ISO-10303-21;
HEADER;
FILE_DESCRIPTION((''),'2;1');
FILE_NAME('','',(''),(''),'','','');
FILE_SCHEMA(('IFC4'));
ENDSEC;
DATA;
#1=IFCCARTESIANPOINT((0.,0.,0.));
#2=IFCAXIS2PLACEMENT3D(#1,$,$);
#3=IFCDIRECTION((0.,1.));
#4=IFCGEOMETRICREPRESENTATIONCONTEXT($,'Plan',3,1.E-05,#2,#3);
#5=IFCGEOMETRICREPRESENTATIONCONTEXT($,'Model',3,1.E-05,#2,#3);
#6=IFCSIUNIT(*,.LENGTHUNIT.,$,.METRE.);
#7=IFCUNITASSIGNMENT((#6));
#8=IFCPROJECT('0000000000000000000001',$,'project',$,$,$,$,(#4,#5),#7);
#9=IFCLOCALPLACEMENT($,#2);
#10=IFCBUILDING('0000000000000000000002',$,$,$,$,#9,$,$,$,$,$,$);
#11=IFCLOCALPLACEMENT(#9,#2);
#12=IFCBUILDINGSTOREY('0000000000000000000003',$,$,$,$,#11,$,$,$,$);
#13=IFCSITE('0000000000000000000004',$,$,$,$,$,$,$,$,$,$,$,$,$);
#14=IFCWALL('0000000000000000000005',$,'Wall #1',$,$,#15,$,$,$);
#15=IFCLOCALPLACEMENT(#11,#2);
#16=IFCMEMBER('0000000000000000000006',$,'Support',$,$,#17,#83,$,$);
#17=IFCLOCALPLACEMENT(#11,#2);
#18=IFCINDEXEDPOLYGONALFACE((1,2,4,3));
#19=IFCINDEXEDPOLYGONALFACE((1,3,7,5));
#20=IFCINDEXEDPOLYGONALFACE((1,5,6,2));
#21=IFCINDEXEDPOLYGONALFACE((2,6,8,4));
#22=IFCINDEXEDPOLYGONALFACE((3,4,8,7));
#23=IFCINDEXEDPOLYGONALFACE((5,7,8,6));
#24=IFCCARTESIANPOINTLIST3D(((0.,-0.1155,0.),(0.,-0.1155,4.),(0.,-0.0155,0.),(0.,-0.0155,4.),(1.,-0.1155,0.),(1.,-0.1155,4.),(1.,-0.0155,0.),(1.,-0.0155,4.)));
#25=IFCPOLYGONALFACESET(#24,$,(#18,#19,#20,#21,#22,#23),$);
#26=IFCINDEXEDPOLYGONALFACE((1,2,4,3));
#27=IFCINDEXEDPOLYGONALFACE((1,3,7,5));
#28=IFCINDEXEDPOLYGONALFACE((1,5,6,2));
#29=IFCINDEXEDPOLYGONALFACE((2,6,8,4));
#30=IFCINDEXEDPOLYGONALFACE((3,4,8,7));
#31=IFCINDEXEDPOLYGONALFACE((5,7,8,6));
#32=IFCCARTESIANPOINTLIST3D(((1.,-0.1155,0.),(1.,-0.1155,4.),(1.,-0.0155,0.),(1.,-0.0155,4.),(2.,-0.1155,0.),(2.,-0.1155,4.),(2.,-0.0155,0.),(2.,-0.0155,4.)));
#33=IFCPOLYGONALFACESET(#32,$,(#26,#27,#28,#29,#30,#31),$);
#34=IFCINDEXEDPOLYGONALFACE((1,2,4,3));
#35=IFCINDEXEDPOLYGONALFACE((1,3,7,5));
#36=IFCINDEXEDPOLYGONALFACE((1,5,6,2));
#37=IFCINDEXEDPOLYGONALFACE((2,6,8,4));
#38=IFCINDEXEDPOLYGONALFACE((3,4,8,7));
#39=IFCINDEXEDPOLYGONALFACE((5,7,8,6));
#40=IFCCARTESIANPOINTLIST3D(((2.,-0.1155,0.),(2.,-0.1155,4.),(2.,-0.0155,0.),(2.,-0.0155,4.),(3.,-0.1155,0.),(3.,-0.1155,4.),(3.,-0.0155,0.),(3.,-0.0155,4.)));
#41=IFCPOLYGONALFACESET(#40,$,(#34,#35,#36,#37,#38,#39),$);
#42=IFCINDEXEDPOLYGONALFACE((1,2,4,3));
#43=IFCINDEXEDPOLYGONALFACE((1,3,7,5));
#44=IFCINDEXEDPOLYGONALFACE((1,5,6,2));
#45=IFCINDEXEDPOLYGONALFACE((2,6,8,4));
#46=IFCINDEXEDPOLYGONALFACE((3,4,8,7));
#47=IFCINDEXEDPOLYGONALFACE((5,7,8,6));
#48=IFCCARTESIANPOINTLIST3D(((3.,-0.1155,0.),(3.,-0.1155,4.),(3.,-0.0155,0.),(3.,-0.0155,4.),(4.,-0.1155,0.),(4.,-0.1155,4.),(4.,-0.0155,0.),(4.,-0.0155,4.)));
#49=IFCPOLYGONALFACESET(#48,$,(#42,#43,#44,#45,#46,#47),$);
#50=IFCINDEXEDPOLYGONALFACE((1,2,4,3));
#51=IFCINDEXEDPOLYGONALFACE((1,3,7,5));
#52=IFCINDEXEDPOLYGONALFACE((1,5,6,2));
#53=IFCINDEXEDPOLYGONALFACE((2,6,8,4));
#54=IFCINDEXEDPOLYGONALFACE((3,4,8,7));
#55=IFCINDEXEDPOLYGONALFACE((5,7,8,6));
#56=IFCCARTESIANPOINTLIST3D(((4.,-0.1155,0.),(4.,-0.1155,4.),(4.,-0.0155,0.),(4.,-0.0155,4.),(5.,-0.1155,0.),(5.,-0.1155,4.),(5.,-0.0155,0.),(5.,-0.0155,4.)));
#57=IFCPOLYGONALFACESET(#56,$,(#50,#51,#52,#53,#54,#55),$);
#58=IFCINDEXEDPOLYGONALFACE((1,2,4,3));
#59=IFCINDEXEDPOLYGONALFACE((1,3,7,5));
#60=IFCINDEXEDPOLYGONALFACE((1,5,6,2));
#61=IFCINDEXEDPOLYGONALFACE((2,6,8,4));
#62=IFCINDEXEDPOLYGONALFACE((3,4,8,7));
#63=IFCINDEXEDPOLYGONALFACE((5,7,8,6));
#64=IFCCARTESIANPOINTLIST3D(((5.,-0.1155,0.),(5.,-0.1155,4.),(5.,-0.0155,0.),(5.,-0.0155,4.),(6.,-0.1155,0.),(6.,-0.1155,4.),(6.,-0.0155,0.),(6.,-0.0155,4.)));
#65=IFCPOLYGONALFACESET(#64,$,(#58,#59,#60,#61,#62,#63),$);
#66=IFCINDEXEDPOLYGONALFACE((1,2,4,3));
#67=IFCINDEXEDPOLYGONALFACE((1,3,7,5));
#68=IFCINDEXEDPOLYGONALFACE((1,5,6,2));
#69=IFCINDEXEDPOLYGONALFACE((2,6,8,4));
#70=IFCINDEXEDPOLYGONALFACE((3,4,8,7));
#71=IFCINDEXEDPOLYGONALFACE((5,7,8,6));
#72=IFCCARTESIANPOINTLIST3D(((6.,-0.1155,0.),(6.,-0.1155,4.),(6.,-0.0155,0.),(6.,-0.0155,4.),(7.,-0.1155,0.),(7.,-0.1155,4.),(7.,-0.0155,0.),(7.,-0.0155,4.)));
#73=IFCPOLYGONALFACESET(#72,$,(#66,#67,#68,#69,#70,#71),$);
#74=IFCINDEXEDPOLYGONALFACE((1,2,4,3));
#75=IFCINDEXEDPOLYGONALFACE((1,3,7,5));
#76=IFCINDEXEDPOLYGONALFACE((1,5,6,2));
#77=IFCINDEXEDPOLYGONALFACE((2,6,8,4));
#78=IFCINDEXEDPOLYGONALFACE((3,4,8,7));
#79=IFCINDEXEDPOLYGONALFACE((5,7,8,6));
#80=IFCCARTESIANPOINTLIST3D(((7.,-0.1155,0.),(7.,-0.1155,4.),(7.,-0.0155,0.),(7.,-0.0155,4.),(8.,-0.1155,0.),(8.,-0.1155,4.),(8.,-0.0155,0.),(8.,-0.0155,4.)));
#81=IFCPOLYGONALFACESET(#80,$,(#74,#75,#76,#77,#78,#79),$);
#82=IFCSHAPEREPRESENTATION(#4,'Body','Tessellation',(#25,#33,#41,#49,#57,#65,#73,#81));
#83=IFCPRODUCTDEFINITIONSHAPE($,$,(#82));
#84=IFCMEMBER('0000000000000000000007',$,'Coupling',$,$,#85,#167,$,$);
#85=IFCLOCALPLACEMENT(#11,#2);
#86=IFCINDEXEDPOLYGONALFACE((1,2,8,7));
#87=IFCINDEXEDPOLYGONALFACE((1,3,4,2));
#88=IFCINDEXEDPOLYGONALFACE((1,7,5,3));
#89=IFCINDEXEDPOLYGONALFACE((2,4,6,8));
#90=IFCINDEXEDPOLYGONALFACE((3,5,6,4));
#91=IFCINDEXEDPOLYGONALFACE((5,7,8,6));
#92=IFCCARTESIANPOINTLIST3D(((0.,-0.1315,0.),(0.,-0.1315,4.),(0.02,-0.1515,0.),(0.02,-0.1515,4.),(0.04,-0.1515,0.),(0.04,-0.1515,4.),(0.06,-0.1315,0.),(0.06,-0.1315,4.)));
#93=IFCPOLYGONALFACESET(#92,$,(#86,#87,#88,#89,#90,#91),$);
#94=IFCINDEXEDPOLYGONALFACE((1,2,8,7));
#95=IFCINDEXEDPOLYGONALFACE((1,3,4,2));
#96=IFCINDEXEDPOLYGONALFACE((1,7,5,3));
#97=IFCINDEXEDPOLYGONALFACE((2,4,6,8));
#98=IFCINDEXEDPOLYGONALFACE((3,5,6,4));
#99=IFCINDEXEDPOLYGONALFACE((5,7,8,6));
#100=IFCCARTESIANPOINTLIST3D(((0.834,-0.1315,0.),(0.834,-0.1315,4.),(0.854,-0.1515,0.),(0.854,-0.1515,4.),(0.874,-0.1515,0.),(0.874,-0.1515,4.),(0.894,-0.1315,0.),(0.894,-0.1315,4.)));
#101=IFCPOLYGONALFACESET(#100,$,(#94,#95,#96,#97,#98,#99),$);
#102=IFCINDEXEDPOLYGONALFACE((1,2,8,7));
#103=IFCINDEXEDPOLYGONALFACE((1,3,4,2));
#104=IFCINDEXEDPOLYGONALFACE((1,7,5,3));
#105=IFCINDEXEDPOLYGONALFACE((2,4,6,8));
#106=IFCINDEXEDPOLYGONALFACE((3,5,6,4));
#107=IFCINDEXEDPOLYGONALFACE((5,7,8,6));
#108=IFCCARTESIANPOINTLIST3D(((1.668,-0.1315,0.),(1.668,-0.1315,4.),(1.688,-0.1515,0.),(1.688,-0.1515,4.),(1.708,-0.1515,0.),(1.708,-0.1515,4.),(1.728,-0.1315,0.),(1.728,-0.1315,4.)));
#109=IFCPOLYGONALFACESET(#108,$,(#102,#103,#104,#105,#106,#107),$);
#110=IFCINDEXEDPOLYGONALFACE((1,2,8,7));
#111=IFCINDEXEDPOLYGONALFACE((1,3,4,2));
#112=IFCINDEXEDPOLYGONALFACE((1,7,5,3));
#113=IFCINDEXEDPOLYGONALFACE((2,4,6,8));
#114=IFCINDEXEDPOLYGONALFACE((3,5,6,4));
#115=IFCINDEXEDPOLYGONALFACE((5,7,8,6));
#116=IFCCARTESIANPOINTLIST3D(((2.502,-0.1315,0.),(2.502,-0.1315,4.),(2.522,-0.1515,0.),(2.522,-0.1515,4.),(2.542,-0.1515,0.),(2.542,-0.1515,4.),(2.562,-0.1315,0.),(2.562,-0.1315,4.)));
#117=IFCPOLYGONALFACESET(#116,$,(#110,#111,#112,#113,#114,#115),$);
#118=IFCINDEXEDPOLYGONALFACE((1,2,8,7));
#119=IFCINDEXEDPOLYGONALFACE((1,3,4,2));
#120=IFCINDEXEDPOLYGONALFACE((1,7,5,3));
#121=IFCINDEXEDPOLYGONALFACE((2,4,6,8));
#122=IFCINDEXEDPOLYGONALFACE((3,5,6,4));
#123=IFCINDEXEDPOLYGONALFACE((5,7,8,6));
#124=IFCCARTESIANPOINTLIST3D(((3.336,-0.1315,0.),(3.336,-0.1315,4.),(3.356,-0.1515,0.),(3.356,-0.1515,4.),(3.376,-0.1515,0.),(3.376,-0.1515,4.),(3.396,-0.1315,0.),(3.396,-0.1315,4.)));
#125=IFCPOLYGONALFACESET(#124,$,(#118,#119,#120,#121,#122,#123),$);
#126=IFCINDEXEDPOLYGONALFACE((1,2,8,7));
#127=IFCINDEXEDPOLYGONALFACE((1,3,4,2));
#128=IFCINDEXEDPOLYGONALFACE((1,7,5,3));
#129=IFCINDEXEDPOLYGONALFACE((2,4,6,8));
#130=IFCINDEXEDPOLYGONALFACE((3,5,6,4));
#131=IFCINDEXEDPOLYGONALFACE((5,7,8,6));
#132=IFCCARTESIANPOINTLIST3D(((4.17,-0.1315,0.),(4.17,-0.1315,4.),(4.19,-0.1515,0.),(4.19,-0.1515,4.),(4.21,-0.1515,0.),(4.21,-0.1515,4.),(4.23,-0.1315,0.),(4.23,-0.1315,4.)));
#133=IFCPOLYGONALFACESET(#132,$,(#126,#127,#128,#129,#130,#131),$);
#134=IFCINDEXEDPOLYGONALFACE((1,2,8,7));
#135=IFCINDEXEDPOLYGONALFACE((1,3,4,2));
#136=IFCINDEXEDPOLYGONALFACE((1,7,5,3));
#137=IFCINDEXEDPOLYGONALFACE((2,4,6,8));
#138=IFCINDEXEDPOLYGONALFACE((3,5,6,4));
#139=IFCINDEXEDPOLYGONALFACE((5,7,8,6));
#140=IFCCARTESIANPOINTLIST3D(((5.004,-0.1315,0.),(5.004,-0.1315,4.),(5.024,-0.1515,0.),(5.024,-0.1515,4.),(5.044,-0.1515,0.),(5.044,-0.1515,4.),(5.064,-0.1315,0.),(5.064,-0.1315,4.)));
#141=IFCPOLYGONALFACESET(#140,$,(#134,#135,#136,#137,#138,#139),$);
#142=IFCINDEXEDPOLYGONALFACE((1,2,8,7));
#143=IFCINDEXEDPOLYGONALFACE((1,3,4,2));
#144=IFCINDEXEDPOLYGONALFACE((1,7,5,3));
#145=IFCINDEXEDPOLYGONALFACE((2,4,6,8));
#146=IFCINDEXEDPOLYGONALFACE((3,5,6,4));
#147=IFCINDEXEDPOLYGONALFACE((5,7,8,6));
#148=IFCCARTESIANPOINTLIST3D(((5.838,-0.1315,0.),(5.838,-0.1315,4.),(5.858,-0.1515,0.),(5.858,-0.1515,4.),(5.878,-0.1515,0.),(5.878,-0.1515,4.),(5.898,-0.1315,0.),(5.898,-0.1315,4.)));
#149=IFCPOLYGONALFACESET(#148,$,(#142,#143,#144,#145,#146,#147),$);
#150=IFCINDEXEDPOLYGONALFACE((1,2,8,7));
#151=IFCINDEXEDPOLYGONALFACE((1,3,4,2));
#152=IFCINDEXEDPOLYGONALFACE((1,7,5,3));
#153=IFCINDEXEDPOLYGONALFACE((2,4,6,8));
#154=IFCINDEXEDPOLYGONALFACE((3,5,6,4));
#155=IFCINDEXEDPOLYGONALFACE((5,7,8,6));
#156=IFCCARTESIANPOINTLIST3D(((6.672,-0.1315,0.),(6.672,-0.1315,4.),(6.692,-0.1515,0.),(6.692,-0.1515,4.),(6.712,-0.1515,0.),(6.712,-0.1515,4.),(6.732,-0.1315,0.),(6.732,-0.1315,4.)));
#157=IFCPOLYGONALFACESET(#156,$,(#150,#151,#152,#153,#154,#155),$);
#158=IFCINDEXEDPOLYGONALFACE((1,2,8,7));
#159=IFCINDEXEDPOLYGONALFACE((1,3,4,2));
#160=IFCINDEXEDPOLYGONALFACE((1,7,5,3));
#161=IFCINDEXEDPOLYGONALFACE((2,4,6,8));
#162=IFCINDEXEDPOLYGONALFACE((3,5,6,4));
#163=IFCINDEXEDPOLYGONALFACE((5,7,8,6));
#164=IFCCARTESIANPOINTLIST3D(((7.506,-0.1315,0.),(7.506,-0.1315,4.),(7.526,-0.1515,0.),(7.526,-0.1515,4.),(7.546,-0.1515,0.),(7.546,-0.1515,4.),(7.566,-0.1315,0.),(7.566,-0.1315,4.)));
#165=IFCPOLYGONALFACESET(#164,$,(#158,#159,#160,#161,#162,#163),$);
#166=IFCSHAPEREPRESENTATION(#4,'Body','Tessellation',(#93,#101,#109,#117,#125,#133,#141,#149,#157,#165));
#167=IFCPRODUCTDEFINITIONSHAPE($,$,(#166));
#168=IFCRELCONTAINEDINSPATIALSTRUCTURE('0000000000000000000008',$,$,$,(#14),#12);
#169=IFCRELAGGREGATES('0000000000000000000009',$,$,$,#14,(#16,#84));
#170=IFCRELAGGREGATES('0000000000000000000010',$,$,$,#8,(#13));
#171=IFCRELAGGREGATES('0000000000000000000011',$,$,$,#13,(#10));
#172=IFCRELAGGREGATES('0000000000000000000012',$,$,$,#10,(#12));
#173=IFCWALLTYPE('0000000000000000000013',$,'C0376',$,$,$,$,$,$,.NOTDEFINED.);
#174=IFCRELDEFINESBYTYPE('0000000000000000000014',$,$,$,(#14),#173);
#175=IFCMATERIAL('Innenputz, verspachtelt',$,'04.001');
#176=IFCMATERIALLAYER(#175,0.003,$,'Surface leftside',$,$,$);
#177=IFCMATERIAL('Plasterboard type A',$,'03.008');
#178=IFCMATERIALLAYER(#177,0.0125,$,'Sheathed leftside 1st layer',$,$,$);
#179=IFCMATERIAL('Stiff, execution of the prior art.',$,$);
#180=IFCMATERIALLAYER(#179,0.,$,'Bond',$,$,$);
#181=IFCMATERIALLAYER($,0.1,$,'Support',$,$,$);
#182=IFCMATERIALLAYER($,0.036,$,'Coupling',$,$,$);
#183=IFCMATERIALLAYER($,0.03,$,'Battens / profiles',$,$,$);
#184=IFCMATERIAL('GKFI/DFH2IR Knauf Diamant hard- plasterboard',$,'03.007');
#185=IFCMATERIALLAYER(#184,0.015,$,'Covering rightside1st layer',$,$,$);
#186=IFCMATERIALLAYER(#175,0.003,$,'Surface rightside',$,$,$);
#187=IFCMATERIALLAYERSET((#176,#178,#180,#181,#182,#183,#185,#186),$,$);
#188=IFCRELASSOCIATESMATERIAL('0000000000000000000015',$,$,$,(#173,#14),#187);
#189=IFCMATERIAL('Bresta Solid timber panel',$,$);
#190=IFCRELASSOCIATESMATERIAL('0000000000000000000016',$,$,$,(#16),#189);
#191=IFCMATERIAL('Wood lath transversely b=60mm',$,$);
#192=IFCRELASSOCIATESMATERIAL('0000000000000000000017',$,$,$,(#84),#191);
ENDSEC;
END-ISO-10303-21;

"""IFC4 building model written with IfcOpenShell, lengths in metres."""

from ifc_helpers import new_model, si_unit, direction, frame, frame_2d, origin, place, context, project, spatial, polyline, rectangle, outline, extrude, material, layer, layer_set, type_object, element, aggregate, save


model = new_model("IFC4")

# Units and contexts
plan_context = context("Plan", 3, precision=1e-05, world=origin(), true_north=direction((0.0, 1.0)))
model_context = context("Model", 3, precision=1e-05, world=origin(), true_north=direction((0.0, 1.0)))
ifc_project = project(units=[si_unit("LENGTHUNIT", "METRE")], contexts=[plan_context, model_context])

# Site, building, storey
site = spatial("IfcSite", under=ifc_project)
building_placement = place(None, origin())
building = spatial("IfcBuilding", under=site, at=building_placement)
storey_placement = place(building_placement, origin())
storey = spatial("IfcBuildingStorey", under=building, at=storey_placement)

# Wall, members
ifc_material_1 = material(Name="Innenputz, verspachtelt", Category="04.001")
ifc_layer_1 = layer(ifc_material_1, 0.003, Name="Surface leftside")
ifc_material_2 = material(Name="Plasterboard type A", Category="03.008")
ifc_layer_2 = layer(ifc_material_2, 0.0125, Name="Sheathed leftside 1st layer")
ifc_material_3 = material(Name="Stiff, execution of the prior art.")
ifc_layer_3 = layer(ifc_material_3, 0.0, Name="Bond")
ifc_layer_4 = layer(None, 0.1, Name="Support")
ifc_layer_5 = layer(None, 0.036, Name="Coupling")
ifc_layer_6 = layer(None, 0.03, Name="Battens / profiles")
ifc_material_4 = material(Name="GKFI/DFH2IR Knauf Diamant hard- plasterboard", Category="03.007")
ifc_layer_7 = layer(ifc_material_4, 0.015, Name="Covering rightside1st layer")
ifc_layer_8 = layer(ifc_material_1, 0.003, Name="Surface rightside")
ifc_layer_set = layer_set([ifc_layer_1, ifc_layer_2, ifc_layer_3, ifc_layer_4, ifc_layer_5, ifc_layer_6, ifc_layer_7, ifc_layer_8])
wall_type = type_object("IfcWallType", Name="C0376", PredefinedType="NOTDEFINED", material=ifc_layer_set)
wall_placement = place(None, frame((0.0, 0.0, 0.0), z_axis=(0.0, -1.0, 0.0), x_axis=(1.0, 0.0, 0.0)))
wall = element("IfcWall", 1, at=wall_placement, inside=storey, type_object=wall_type, material=ifc_layer_set, Name="Wall #1")
ifc_material_5 = material(Name="Bresta Solid timber panel")
member_1_placement = place(wall_placement, origin())
member_1 = element("IfcMember", 2, at=member_1_placement, material=ifc_material_5, Name="Support", context=plan_context, shape_type="SweptSolid", body=[
    extrude(rectangle(XDim=1.0, YDim=0.1, at=frame_2d((0.5, 0.05), x_axis=(1.0, 0.0))), frame((0.0, 4.0, 0.0155), z_axis=(0.0, -1.0, 0.0), x_axis=(1.0, 0.0, 0.0)), (0.0, 0.0, 1.0), 4.0),
    extrude(rectangle(XDim=1.0, YDim=0.1, at=frame_2d((0.5, 0.05), x_axis=(1.0, 0.0))), frame((1.0, 4.0, 0.0155), z_axis=(0.0, -1.0, 0.0), x_axis=(1.0, 0.0, 0.0)), (0.0, 0.0, 1.0), 4.0),
    extrude(rectangle(XDim=1.0, YDim=0.1, at=frame_2d((0.5, 0.05), x_axis=(1.0, 0.0))), frame((2.0, 4.0, 0.0155), z_axis=(0.0, -1.0, 0.0), x_axis=(1.0, 0.0, 0.0)), (0.0, 0.0, 1.0), 4.0),
    extrude(rectangle(XDim=1.0, YDim=0.1, at=frame_2d((0.5, 0.05), x_axis=(1.0, 0.0))), frame((3.0, 4.0, 0.0155), z_axis=(0.0, -1.0, 0.0), x_axis=(1.0, 0.0, 0.0)), (0.0, 0.0, 1.0), 4.0),
    extrude(rectangle(XDim=1.0, YDim=0.1, at=frame_2d((0.5, 0.05), x_axis=(1.0, 0.0))), frame((4.0, 4.0, 0.0155), z_axis=(0.0, -1.0, 0.0), x_axis=(1.0, 0.0, 0.0)), (0.0, 0.0, 1.0), 4.0),
    extrude(rectangle(XDim=1.0, YDim=0.1, at=frame_2d((0.5, 0.05), x_axis=(1.0, 0.0))), frame((5.0, 4.0, 0.0155), z_axis=(0.0, -1.0, 0.0), x_axis=(1.0, 0.0, 0.0)), (0.0, 0.0, 1.0), 4.0),
    extrude(rectangle(XDim=1.0, YDim=0.1, at=frame_2d((0.5, 0.05), x_axis=(1.0, 0.0))), frame((6.0, 4.0, 0.0155), z_axis=(0.0, -1.0, 0.0), x_axis=(1.0, 0.0, 0.0)), (0.0, 0.0, 1.0), 4.0),
    extrude(rectangle(XDim=1.0, YDim=0.1, at=frame_2d((0.5, 0.05), x_axis=(1.0, 0.0))), frame((7.0, 4.0, 0.0155), z_axis=(0.0, -1.0, 0.0), x_axis=(1.0, 0.0, 0.0)), (0.0, 0.0, 1.0), 4.0),
])
ifc_material_6 = material(Name="Wood lath transversely b=60mm")
member_2_placement = place(wall_placement, origin())
member_2 = element("IfcMember", 3, at=member_2_placement, material=ifc_material_6, Name="Coupling", context=plan_context, shape_type="SweptSolid", body=[
    extrude(outline(polyline([(0.0, 0.0), (0.06, 0.0), (0.04, 0.02), (0.02, 0.02), (0.0, 0.0)])), frame((0.0, 4.0, 0.1315), z_axis=(0.0, -1.0, 0.0), x_axis=(1.0, 0.0, 0.0)), (0.0, 0.0, 1.0), 4.0),
    extrude(outline(polyline([(0.0, 0.0), (0.06, 0.0), (0.04, 0.02), (0.02, 0.02), (0.0, 0.0)])), frame((0.834, 4.0, 0.1315), z_axis=(0.0, -1.0, 0.0), x_axis=(1.0, 0.0, 0.0)), (0.0, 0.0, 1.0), 4.0),
    extrude(outline(polyline([(0.0, 0.0), (0.06, 0.0), (0.04, 0.02), (0.02, 0.02), (0.0, 0.0)])), frame((1.668, 4.0, 0.1315), z_axis=(0.0, -1.0, 0.0), x_axis=(1.0, 0.0, 0.0)), (0.0, 0.0, 1.0), 4.0),
    extrude(outline(polyline([(0.0, 0.0), (0.06, 0.0), (0.04, 0.02), (0.02, 0.02), (0.0, 0.0)])), frame((2.502, 4.0, 0.1315), z_axis=(0.0, -1.0, 0.0), x_axis=(1.0, 0.0, 0.0)), (0.0, 0.0, 1.0), 4.0),
    extrude(outline(polyline([(0.0, 0.0), (0.06, 0.0), (0.04, 0.02), (0.02, 0.02), (0.0, 0.0)])), frame((3.336, 4.0, 0.1315), z_axis=(0.0, -1.0, 0.0), x_axis=(1.0, 0.0, 0.0)), (0.0, 0.0, 1.0), 4.0),
    extrude(outline(polyline([(0.0, 0.0), (0.06, 0.0), (0.04, 0.02), (0.02, 0.02), (0.0, 0.0)])), frame((4.17, 4.0, 0.1315), z_axis=(0.0, -1.0, 0.0), x_axis=(1.0, 0.0, 0.0)), (0.0, 0.0, 1.0), 4.0),
    extrude(outline(polyline([(0.0, 0.0), (0.06, 0.0), (0.04, 0.02), (0.02, 0.02), (0.0, 0.0)])), frame((5.004, 4.0, 0.1315), z_axis=(0.0, -1.0, 0.0), x_axis=(1.0, 0.0, 0.0)), (0.0, 0.0, 1.0), 4.0),
    extrude(outline(polyline([(0.0, 0.0), (0.06, 0.0), (0.04, 0.02), (0.02, 0.02), (0.0, 0.0)])), frame((5.838, 4.0, 0.1315), z_axis=(0.0, -1.0, 0.0), x_axis=(1.0, 0.0, 0.0)), (0.0, 0.0, 1.0), 4.0),
    extrude(outline(polyline([(0.0, 0.0), (0.06, 0.0), (0.04, 0.02), (0.02, 0.02), (0.0, 0.0)])), frame((6.672, 4.0, 0.1315), z_axis=(0.0, -1.0, 0.0), x_axis=(1.0, 0.0, 0.0)), (0.0, 0.0, 1.0), 4.0),
    extrude(outline(polyline([(0.0, 0.0), (0.06, 0.0), (0.04, 0.02), (0.02, 0.02), (0.0, 0.0)])), frame((7.506, 4.0, 0.1315), z_axis=(0.0, -1.0, 0.0), x_axis=(1.0, 0.0, 0.0)), (0.0, 0.0, 1.0), 4.0),
])
aggregate(wall, [member_1, member_2])

save(model, "model.ifc")
